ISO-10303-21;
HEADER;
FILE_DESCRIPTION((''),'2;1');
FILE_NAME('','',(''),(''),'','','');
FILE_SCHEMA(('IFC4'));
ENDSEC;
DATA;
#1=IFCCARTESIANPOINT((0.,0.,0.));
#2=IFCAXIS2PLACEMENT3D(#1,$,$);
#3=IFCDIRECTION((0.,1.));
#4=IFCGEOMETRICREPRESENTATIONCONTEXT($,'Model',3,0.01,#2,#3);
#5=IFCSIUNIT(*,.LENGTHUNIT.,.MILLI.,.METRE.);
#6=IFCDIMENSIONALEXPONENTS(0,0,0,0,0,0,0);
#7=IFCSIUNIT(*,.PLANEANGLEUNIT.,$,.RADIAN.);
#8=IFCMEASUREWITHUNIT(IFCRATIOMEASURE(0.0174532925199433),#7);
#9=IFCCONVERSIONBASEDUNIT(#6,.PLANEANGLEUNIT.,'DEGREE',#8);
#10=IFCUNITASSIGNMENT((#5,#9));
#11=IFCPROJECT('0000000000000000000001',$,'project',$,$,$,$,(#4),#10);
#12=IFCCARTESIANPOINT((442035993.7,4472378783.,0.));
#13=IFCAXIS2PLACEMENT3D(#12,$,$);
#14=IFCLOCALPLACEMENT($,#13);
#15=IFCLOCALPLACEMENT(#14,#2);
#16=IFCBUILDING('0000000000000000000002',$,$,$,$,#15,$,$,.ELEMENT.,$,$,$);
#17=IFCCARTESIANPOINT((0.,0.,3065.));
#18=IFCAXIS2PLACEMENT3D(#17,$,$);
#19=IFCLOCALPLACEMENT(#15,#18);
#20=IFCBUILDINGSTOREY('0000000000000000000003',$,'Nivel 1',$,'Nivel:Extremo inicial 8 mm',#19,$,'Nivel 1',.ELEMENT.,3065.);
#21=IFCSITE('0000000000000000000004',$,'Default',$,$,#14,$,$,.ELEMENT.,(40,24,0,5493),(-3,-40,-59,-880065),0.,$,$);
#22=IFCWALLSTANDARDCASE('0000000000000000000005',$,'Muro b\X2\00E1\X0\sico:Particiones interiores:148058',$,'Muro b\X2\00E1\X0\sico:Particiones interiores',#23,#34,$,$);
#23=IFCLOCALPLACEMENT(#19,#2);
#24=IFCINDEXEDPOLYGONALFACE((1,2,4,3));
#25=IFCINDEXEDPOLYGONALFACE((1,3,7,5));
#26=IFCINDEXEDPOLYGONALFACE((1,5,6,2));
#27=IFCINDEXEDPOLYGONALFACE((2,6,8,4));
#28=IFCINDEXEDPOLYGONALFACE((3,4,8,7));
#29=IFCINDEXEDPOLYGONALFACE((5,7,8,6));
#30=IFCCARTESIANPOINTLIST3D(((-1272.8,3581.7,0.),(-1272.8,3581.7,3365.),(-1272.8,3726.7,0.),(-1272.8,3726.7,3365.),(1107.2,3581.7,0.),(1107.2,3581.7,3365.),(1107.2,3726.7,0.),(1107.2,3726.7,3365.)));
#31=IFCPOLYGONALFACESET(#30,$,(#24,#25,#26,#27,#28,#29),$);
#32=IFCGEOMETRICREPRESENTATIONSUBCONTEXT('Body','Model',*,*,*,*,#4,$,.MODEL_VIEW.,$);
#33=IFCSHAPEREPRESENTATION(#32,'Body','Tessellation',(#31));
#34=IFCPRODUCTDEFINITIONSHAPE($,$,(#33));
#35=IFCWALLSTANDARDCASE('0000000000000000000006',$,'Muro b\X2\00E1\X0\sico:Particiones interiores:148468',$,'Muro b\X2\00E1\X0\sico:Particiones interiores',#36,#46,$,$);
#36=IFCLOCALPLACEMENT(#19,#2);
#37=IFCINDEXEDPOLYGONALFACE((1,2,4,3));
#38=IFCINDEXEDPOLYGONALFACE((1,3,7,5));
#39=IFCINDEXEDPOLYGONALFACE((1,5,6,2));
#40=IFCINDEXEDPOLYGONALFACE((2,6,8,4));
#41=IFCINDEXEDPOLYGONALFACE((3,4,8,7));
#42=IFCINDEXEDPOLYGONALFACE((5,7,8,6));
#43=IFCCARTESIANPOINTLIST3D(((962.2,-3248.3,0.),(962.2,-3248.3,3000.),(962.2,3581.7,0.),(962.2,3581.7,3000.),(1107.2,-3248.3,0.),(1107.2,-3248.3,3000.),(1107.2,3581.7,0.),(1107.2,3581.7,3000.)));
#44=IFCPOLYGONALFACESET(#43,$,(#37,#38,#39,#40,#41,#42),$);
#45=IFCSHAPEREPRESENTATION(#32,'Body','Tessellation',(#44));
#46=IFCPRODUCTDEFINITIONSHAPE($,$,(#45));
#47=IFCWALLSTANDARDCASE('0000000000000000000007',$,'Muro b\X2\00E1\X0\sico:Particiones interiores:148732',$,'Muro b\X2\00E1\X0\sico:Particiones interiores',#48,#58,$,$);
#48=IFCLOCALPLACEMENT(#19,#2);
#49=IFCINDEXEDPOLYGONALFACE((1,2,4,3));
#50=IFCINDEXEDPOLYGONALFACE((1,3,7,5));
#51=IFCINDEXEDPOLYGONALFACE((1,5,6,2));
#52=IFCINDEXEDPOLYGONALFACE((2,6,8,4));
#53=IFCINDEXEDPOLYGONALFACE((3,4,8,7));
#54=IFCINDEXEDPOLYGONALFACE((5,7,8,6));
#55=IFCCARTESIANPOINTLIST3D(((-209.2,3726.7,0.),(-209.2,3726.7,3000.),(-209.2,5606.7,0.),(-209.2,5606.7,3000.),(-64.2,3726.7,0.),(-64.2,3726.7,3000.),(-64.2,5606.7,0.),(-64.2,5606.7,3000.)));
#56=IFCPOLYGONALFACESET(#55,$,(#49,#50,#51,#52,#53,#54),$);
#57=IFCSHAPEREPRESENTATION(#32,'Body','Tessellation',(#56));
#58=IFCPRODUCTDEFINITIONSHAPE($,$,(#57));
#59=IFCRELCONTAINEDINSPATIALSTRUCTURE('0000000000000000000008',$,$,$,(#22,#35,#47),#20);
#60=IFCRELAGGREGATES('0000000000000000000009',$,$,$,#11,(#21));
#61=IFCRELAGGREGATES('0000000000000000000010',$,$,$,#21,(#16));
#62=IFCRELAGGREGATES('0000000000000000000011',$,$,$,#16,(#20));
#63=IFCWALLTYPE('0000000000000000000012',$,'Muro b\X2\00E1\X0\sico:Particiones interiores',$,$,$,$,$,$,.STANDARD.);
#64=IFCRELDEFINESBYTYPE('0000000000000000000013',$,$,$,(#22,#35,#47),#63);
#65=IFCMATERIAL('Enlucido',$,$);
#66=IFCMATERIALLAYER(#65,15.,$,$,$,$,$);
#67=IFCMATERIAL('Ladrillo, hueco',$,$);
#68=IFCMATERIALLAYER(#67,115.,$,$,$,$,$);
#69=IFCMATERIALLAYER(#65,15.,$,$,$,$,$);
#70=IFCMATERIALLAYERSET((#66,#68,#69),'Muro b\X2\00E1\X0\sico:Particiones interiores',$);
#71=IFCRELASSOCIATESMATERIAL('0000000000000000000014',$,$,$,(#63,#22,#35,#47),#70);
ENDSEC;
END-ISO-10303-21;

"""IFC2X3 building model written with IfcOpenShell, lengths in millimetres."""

from ifc_helpers import new_model, entity, si_unit, converted_unit, direction, frame, frame_2d, origin, place, context, subcontext, project, spatial, polyline, rectangle, extrude, clip, bounded_halfspace, material, layer, layer_set, layer_usage, type_object, element, save


model = new_model("IFC2X3")

# Units and contexts
model_context = context("Model", 3, precision=0.01, world=origin(), true_north=direction((0.0, 1.0)))
body_context = subcontext(model_context, "Body", "Model", "MODEL_VIEW")
ifc_project = project(units=[si_unit("LENGTHUNIT", "METRE", prefix="MILLI"), converted_unit("PLANEANGLEUNIT", "DEGREE", entity("IfcRatioMeasure", 0.0174532925199433), si_unit("PLANEANGLEUNIT", "RADIAN"), dimensions=[0, 0, 0, 0, 0, 0, 0])], contexts=[model_context])

# Site, building, storey
site_placement = place(None, frame((442035993.7, 4472378783.0, 0.0)))
site = spatial("IfcSite", under=ifc_project, at=site_placement, Name="Default", CompositionType="ELEMENT", RefLatitude=(40, 24, 0, 5493), RefLongitude=(-3, -40, -59, -880065), RefElevation=0.0)
building_placement = place(site_placement, origin())
building = spatial("IfcBuilding", under=site, at=building_placement, CompositionType="ELEMENT")
storey_placement = place(building_placement, frame((0.0, 0.0, 3065.0)))
storey = spatial("IfcBuildingStorey", under=building, at=storey_placement, Name="Nivel 1", ObjectType="Nivel:Extremo inicial 8 mm", LongName="Nivel 1", CompositionType="ELEMENT", Elevation=3065.0)

# Shared definitions
ifc_material_1 = material(Name="Enlucido")

# Walls
ifc_layer_1 = layer(ifc_material_1, 15.0)
ifc_material_2 = material(Name="Ladrillo, hueco")
ifc_layer_2 = layer(ifc_material_2, 115.0)
ifc_layer_3 = layer(ifc_material_1, 15.0)
ifc_layer_set_1 = layer_set([ifc_layer_1, ifc_layer_2, ifc_layer_3], Name="Muro básico:Particiones interiores")
wall_type_1 = type_object("IfcWallType", Name="Muro básico:Particiones interiores", PredefinedType="STANDARD", material=ifc_layer_set_1)
ifc_layer_usage_1 = layer_usage(ifc_layer_set_1, "AXIS2", "NEGATIVE", 72.5)
wall_1_placement = place(storey_placement, frame((-1272.8, 3654.2, 0.0)))
element("IfcWallStandardCase", 1, at=wall_1_placement, inside=storey, type_object=wall_type_1, material=ifc_layer_usage_1, Name="Muro básico:Particiones interiores:148058", ObjectType="Muro básico:Particiones interiores", context=body_context, shape_type="SweptSolid", body=[
    extrude(rectangle(XDim=2380.0, YDim=145.0, at=frame_2d((1190.0, 0.0), x_axis=(-1.0, 0.0))), origin(), (0.0, 0.0, 1.0), 3365.0),
])
ifc_layer_usage_2 = layer_usage(ifc_layer_set_1, "AXIS2", "NEGATIVE", 72.5)
wall_2_placement = place(storey_placement, frame((1034.7, 3581.7, 0.0), z_axis=(0.0, 0.0, 1.0), x_axis=(0.0, -1.0, 0.0)))
element("IfcWallStandardCase", 2, at=wall_2_placement, inside=storey, type_object=wall_type_1, material=ifc_layer_usage_2, Name="Muro básico:Particiones interiores:148468", ObjectType="Muro básico:Particiones interiores", context=body_context, shape_type="Clipping", body=[
    clip(extrude(rectangle(XDim=6830.0, YDim=145.0, at=frame_2d((3415.0, 0.0), x_axis=(-1.0, 0.0))), origin(), (0.0, 0.0, 1.0), 3000.0), bounded_halfspace(frame((0.0, -72.5, 3000.0), z_axis=(0.0, 0.0, -1.0), x_axis=(0.0, -1.0, 0.0)), True, frame((0.0, -72.5, 3000.0), z_axis=(0.0, 0.0, -1.0), x_axis=(0.0, -1.0, 0.0)), polyline([(0.0, 0.0), (-145.0, 0.0), (-145.0, -6830.0), (0.0, -6830.0), (0.0, 0.0)]))),
])
ifc_layer_usage_3 = layer_usage(ifc_layer_set_1, "AXIS2", "NEGATIVE", 72.5)
wall_3_placement = place(storey_placement, frame((-136.7, 3726.7, 0.0), z_axis=(0.0, 0.0, 1.0), x_axis=(0.0, 1.0, 0.0)))
element("IfcWallStandardCase", 3, at=wall_3_placement, inside=storey, type_object=wall_type_1, material=ifc_layer_usage_3, Name="Muro básico:Particiones interiores:148732", ObjectType="Muro básico:Particiones interiores", context=body_context, shape_type="Clipping", body=[
    clip(extrude(rectangle(XDim=1880.0, YDim=145.0, at=frame_2d((940.0, 0.0), x_axis=(-1.0, 0.0))), origin(), (0.0, 0.0, 1.0), 3000.0), bounded_halfspace(frame((0.0, -72.5, 3000.0), z_axis=(0.0, 0.0, -1.0), x_axis=(0.0, 1.0, 0.0)), True, frame((0.0, -72.5, 3000.0), z_axis=(0.0, 0.0, -1.0), x_axis=(0.0, 1.0, 0.0)), polyline([(0.0, 0.0), (145.0, 0.0), (145.0, 1880.0), (0.0, 1880.0), (0.0, 0.0)]))),
])

save(model, "model.ifc")
